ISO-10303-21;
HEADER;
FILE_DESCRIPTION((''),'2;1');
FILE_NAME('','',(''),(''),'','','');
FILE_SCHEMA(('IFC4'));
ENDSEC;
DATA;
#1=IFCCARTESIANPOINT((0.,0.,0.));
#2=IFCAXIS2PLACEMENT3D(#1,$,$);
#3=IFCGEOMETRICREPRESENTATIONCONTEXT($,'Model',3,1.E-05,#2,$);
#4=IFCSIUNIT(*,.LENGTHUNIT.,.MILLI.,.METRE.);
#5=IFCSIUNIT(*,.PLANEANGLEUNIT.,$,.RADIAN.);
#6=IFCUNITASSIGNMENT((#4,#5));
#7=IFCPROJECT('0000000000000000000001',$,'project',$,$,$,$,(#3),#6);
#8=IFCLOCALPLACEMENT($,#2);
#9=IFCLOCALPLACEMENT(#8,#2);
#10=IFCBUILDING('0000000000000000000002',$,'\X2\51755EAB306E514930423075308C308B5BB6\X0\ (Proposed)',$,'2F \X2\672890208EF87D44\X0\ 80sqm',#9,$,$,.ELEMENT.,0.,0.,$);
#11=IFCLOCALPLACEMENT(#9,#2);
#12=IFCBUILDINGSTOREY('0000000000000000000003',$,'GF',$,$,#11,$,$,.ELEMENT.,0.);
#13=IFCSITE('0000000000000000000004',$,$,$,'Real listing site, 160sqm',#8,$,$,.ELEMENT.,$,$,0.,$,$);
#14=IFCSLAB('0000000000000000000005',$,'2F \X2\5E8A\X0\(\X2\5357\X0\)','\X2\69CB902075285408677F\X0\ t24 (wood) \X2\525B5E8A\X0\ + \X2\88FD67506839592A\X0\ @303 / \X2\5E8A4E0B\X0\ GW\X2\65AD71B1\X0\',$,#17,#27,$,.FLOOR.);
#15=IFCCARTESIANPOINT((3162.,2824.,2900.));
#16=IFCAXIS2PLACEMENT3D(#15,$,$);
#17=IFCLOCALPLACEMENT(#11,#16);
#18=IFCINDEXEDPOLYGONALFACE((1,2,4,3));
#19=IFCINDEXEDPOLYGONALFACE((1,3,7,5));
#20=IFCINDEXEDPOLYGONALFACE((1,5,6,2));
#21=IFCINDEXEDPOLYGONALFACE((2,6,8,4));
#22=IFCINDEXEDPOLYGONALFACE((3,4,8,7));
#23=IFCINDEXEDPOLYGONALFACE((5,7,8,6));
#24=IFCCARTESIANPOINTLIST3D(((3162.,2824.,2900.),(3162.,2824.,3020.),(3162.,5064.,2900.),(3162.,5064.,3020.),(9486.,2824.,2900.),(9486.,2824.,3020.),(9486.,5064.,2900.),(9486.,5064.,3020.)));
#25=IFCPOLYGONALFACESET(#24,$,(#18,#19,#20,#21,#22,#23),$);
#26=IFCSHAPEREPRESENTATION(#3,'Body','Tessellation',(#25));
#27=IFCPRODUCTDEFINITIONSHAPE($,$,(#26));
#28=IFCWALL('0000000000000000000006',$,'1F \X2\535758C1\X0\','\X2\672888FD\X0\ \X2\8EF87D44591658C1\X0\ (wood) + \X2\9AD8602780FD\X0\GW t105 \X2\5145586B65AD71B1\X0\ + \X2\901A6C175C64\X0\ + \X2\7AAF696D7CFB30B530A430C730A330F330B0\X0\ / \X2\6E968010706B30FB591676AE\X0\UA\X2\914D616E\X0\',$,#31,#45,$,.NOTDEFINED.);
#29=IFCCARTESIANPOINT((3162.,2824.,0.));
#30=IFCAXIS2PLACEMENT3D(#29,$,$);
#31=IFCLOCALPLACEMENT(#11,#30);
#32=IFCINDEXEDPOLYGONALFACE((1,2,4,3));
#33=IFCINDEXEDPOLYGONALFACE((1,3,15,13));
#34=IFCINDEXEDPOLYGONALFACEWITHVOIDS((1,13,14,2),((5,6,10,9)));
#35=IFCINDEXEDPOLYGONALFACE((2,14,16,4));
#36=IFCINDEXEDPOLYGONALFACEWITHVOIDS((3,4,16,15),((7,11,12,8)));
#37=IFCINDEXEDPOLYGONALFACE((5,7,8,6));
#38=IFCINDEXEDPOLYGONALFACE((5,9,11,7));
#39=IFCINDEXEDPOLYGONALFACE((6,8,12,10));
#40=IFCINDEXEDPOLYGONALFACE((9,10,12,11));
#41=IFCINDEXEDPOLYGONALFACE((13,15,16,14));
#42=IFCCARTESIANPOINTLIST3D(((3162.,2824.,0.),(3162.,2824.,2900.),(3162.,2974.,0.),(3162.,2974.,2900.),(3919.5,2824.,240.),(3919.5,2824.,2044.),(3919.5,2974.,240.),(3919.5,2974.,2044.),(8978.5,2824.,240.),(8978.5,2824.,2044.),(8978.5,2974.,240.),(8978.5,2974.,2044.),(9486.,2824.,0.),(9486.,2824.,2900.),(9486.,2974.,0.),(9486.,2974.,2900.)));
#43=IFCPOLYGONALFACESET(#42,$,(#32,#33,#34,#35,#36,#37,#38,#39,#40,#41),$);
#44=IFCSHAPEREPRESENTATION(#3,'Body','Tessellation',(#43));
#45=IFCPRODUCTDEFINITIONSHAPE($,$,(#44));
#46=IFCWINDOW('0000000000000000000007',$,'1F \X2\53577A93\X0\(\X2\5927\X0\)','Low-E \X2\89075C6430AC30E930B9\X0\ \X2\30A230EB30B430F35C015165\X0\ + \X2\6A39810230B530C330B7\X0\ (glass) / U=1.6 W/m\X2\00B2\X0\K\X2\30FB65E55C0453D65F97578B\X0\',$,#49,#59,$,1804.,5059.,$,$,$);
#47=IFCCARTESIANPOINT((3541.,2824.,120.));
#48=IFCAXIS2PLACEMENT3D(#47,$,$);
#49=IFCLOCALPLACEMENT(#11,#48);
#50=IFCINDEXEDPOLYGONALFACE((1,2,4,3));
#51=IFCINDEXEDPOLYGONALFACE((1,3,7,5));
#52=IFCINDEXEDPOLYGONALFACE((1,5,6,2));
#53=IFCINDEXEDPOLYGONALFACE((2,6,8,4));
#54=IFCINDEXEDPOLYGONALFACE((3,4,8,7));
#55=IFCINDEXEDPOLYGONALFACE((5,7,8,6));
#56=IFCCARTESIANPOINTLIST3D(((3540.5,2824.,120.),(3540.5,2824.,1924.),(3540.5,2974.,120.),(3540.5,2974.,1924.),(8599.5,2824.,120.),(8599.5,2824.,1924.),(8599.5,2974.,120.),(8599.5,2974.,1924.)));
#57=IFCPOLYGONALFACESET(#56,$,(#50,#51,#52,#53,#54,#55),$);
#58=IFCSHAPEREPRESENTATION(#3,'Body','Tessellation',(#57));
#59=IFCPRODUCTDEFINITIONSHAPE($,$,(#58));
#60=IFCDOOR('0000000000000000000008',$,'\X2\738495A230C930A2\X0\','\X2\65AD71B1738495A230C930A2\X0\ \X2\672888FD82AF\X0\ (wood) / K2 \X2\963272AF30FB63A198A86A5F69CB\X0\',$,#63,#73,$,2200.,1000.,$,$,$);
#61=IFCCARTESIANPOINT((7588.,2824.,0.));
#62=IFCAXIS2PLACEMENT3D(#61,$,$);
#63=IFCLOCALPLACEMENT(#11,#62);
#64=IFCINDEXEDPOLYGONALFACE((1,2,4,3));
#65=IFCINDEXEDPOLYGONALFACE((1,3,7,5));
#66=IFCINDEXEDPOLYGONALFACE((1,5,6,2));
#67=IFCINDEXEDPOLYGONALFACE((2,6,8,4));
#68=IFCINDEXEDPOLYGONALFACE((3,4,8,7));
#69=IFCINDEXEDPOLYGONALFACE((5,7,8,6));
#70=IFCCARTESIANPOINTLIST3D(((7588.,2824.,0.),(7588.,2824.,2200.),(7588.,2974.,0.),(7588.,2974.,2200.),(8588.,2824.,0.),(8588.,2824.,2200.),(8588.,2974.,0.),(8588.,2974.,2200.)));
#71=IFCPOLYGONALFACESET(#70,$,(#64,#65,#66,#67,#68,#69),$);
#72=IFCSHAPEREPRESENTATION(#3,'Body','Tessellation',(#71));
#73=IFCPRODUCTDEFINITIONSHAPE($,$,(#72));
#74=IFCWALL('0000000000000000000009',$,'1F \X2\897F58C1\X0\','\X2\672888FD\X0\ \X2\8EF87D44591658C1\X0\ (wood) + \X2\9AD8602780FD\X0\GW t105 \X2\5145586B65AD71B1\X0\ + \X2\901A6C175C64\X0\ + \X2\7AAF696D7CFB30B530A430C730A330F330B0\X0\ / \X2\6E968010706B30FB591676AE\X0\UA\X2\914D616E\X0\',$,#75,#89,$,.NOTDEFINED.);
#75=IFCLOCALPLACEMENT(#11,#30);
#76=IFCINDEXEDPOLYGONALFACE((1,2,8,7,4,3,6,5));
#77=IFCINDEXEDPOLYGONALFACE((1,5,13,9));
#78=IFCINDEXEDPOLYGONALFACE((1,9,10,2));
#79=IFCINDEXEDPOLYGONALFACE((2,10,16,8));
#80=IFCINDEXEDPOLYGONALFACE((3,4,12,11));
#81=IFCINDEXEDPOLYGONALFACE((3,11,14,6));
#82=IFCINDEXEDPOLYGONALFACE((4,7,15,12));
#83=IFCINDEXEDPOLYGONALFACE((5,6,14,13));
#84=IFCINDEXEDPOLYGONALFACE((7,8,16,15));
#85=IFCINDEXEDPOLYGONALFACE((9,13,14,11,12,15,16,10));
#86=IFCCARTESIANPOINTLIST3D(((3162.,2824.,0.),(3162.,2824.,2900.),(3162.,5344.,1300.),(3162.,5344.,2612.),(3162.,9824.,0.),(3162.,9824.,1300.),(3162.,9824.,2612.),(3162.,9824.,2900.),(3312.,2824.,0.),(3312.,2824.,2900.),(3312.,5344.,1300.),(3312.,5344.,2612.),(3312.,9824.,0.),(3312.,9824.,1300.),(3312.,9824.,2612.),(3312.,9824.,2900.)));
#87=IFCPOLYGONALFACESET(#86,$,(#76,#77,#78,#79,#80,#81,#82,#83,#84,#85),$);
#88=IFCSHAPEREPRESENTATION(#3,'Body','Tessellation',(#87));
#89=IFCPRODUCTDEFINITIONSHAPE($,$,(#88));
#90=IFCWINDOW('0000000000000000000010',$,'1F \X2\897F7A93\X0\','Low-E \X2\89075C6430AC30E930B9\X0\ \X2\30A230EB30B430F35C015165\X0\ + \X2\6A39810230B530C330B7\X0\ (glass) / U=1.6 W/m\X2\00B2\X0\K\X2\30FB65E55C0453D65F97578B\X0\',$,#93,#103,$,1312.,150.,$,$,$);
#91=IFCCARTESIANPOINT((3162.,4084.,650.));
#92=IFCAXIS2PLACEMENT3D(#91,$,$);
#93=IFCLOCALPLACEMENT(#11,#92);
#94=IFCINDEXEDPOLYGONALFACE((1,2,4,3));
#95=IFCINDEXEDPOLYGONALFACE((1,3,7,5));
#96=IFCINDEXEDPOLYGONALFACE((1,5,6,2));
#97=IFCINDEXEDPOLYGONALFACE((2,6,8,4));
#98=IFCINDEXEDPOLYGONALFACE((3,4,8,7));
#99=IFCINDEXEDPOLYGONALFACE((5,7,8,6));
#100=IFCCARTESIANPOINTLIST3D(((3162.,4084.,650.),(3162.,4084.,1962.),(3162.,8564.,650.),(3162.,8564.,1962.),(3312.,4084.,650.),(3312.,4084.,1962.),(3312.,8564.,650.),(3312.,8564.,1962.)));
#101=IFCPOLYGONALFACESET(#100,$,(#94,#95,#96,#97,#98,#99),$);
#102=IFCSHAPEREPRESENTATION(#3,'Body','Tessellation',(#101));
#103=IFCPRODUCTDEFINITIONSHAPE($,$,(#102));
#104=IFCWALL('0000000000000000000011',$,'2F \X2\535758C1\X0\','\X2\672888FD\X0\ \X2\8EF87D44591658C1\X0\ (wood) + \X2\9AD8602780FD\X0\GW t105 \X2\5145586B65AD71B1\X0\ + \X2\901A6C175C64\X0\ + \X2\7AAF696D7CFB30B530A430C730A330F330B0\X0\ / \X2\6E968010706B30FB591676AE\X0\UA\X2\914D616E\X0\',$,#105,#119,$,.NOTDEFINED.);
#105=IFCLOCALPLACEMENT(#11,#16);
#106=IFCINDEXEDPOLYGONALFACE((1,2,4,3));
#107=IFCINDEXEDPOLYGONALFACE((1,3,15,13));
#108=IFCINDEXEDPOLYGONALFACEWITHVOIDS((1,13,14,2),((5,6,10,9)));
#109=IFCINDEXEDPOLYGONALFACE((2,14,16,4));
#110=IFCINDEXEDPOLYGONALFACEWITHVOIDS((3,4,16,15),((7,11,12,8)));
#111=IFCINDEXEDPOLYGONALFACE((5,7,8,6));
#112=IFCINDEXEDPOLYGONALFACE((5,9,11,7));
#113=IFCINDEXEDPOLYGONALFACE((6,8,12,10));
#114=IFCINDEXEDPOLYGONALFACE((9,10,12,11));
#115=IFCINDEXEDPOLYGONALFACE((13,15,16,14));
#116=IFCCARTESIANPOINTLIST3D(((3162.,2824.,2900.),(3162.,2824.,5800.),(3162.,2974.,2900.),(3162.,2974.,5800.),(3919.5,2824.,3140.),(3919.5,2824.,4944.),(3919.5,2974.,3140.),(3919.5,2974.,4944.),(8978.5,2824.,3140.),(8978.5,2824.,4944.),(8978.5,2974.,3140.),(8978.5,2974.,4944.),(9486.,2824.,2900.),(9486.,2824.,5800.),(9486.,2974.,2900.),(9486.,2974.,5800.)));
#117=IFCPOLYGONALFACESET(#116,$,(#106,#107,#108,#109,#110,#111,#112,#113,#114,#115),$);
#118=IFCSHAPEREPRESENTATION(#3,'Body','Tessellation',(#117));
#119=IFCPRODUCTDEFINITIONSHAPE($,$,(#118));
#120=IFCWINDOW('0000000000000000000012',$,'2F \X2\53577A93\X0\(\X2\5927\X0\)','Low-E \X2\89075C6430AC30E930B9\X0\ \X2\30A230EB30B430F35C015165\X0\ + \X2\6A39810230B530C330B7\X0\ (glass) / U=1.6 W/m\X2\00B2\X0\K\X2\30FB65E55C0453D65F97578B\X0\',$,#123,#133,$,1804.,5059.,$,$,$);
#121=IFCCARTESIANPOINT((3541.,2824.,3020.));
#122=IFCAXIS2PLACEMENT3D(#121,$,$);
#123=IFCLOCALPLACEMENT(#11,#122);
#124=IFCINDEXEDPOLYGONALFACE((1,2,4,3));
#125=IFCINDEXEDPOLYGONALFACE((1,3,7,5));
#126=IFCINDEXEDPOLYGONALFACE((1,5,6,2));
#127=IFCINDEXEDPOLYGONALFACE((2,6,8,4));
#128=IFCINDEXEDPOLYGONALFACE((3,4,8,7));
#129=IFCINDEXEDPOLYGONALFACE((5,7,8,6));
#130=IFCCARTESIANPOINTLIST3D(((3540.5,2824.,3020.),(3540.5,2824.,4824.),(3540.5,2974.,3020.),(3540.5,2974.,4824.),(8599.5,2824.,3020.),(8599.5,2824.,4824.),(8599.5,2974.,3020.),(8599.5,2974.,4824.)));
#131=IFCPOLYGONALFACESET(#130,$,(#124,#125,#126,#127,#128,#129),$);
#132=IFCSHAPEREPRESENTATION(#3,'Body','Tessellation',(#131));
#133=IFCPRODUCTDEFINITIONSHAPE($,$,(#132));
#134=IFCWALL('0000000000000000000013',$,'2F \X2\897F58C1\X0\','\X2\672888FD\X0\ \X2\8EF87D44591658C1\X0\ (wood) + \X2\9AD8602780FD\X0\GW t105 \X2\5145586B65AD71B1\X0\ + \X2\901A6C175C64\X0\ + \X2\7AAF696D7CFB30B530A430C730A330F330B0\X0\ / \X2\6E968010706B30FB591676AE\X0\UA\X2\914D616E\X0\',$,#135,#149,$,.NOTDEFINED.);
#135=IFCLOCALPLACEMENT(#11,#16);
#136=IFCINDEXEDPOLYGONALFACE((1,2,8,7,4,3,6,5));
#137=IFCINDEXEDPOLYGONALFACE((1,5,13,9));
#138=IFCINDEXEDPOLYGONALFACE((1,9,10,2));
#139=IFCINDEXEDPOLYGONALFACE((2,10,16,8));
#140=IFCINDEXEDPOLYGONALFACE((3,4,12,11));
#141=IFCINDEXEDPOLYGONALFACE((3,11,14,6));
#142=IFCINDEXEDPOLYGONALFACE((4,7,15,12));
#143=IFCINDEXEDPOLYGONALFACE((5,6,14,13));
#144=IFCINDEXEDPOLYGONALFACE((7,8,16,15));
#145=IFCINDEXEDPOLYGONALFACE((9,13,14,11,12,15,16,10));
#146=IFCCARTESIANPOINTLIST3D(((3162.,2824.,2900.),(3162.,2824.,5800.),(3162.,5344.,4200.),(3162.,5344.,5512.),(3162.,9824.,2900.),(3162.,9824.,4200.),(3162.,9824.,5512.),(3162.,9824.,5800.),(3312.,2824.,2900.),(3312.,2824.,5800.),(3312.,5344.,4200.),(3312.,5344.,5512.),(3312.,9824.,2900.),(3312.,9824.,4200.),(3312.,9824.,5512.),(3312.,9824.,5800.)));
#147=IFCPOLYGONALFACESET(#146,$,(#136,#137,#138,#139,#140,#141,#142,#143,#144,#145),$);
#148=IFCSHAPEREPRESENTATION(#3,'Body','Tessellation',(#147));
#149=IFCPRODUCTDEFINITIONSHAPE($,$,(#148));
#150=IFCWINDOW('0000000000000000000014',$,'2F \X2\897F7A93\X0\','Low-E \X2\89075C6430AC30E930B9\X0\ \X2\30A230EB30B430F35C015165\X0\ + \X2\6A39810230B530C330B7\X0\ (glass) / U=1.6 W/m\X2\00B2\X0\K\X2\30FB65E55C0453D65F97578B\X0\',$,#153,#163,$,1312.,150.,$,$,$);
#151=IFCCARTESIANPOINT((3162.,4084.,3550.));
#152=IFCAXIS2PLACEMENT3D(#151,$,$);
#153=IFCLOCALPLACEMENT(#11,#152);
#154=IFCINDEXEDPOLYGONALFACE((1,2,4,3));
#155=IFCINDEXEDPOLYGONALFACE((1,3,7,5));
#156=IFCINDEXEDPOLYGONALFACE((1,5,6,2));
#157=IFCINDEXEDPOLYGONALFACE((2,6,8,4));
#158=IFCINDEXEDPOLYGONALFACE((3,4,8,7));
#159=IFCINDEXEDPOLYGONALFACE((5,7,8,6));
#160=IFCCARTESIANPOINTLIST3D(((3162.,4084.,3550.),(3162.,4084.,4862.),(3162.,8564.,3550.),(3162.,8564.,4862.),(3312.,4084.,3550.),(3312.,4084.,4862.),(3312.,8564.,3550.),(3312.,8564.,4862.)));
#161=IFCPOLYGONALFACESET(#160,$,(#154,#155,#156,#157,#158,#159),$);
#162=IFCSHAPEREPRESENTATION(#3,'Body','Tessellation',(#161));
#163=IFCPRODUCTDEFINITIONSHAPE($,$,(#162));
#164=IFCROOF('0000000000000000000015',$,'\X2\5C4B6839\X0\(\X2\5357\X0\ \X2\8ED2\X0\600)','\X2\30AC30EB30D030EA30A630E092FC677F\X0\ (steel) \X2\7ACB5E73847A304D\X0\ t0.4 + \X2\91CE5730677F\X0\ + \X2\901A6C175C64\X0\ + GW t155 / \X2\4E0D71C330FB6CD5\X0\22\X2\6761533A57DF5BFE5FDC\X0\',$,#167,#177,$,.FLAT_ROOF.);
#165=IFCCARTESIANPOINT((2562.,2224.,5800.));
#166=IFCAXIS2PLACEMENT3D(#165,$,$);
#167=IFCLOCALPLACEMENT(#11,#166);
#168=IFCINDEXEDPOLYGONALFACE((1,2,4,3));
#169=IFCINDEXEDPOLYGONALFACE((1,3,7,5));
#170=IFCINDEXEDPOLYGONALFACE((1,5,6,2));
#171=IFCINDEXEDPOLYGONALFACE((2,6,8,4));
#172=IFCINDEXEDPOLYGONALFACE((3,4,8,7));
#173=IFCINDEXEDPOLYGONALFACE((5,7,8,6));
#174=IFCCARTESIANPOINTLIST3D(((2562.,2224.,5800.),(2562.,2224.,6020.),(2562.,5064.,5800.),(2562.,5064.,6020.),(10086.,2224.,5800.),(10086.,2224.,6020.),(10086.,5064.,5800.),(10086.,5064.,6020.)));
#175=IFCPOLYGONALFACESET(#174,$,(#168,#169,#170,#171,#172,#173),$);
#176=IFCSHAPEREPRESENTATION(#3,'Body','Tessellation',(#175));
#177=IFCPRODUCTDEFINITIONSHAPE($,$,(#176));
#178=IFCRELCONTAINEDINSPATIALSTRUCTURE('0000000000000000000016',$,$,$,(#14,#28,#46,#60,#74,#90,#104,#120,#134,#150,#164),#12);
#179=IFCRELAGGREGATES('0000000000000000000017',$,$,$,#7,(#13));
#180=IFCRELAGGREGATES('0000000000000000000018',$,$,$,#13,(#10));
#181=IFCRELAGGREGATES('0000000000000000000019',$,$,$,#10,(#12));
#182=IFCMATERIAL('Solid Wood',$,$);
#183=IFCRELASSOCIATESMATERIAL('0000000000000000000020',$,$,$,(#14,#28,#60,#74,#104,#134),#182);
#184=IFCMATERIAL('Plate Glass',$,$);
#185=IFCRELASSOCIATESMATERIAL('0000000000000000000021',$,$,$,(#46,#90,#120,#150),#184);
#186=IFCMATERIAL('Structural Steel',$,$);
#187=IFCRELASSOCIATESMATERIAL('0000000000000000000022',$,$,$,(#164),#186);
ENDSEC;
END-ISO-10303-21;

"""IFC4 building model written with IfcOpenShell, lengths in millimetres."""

from ifc_helpers import new_model, si_unit, frame, frame_2d, origin, place, context, project, spatial, rectangle, extrude, material, element, fill, save


model = new_model("IFC4")

# Units and contexts
model_context = context("Model", 3, precision=1e-05, world=origin())
ifc_project = project(units=[si_unit("LENGTHUNIT", "METRE", prefix="MILLI"), si_unit("PLANEANGLEUNIT", "RADIAN")], contexts=[model_context])

# Site, building, storey
site_placement = place(None, origin())
site = spatial("IfcSite", under=ifc_project, at=site_placement, ObjectType="Real listing site, 160sqm", CompositionType="ELEMENT", RefElevation=0.0)
building_placement = place(site_placement, origin())
building = spatial("IfcBuilding", under=site, at=building_placement, Name="兵庫の光あふれる家 (Proposed)", ObjectType="2F 木造軸組 80sqm", CompositionType="ELEMENT", ElevationOfRefHeight=0.0, ElevationOfTerrain=0.0)
storey_placement = place(building_placement, origin())
storey = spatial("IfcBuildingStorey", under=building, at=storey_placement, Name="GF", CompositionType="ELEMENT", Elevation=0.0)

# Slab
ifc_material_1 = material(Name="Solid Wood")
slab_1_placement = place(storey_placement, frame((3162.0, 2824.0, 2900.0)))
element("IfcSlab", 1, at=slab_1_placement, inside=storey, material=ifc_material_1, Name="2F 床(南)", Description="構造用合板 t24 (wood) 剛床 + 製材根太 @303 / 床下 GW断熱", PredefinedType="FLOOR", context=model_context, shape_type="SweptSolid", body=[
    extrude(rectangle(XDim=6324.0, YDim=2240.0, at=frame_2d((3162.0, 1120.0))), frame((3162.0, 2824.0, 2900.0)), (0.0, 0.0, 1.0), 120.0),
])

# Wall, openings, window, door
wall_1_placement = place(storey_placement, frame((3162.0, 2824.0, 0.0)))
wall_1 = element("IfcWall", 2, at=wall_1_placement, inside=storey, material=ifc_material_1, Name="1F 南壁", Description="木製 軸組外壁 (wood) + 高性能GW t105 充填断熱 + 通気層 + 窯業系サイディング / 準耐火・外皮UA配慮", PredefinedType="NOTDEFINED", context=model_context, shape_type="SweptSolid", body=[
    extrude(rectangle(XDim=6324.0, YDim=150.0, at=frame_2d((3162.0, 75.0))), frame((3162.0, 2824.0, 0.0)), (0.0, 0.0, 1.0), 2900.0),
])
opening_1_placement = place(storey_placement, frame((3541.0, 2824.0, 120.0)))
opening_1 = element("IfcOpeningElement", 3, at=opening_1_placement, cuts=wall_1, PredefinedType="NOTDEFINED", context=model_context, shape_type="SweptSolid", body=[
    extrude(rectangle(XDim=5059.0, YDim=150.0, at=frame_2d((2529.0, 75.0))), frame((3541.0, 2824.0, 120.0)), (0.0, 0.0, 1.0), 1804.0),
])
opening_2_placement = place(storey_placement, frame((7588.0, 2824.0, 0.0)))
opening_2 = element("IfcOpeningElement", 4, at=opening_2_placement, cuts=wall_1, PredefinedType="NOTDEFINED", context=model_context, shape_type="SweptSolid", body=[
    extrude(rectangle(XDim=1000.0, YDim=150.0, at=frame_2d((500.0, 75.0))), frame((7588.0, 2824.0, 0.0)), (0.0, 0.0, 1.0), 2200.0),
])
ifc_material_2 = material(Name="Plate Glass")
window_1_placement = place(storey_placement, frame((3541.0, 2824.0, 120.0)))
window_1 = element("IfcWindow", 5, at=window_1_placement, inside=storey, material=ifc_material_2, Name="1F 南窓(大)", Description="Low-E 複層ガラス アルゴン封入 + 樹脂サッシ (glass) / U=1.6 W/m²K・日射取得型", OverallHeight=1804.0, OverallWidth=5059.0, context=model_context, shape_type="SweptSolid", body=[
    extrude(rectangle(XDim=5059.0, YDim=150.0, at=frame_2d((2529.0, 75.0))), frame((3541.0, 2824.0, 120.0)), (0.0, 0.0, 1.0), 1804.0),
])
fill(opening_1, window_1)
door_placement = place(storey_placement, frame((7588.0, 2824.0, 0.0)))
door = element("IfcDoor", 6, at=door_placement, inside=storey, material=ifc_material_1, Name="玄関ドア", Description="断熱玄関ドア 木製芯 (wood) / K2 防犯・採風機構", OverallHeight=2200.0, OverallWidth=1000.0, context=model_context, shape_type="SweptSolid", body=[
    extrude(rectangle(XDim=1000.0, YDim=150.0, at=frame_2d((500.0, 75.0))), frame((7588.0, 2824.0, 0.0)), (0.0, 0.0, 1.0), 2200.0),
])
fill(opening_2, door)

# Walls, openings, windows
wall_2_placement = place(storey_placement, frame((3162.0, 2824.0, 0.0)))
wall_2 = element("IfcWall", 7, at=wall_2_placement, inside=storey, material=ifc_material_1, Name="1F 西壁", Description="木製 軸組外壁 (wood) + 高性能GW t105 充填断熱 + 通気層 + 窯業系サイディング / 準耐火・外皮UA配慮", PredefinedType="NOTDEFINED", context=model_context, shape_type="SweptSolid", body=[
    extrude(rectangle(XDim=150.0, YDim=7000.0, at=frame_2d((75.0, 3500.0))), frame((3162.0, 2824.0, 0.0)), (0.0, 0.0, 1.0), 2900.0),
])
opening_3_placement = place(storey_placement, frame((3162.0, 4084.0, 650.0)))
opening_3 = element("IfcOpeningElement", 8, at=opening_3_placement, cuts=wall_2, PredefinedType="NOTDEFINED", context=model_context, shape_type="SweptSolid", body=[
    extrude(rectangle(XDim=150.0, YDim=4480.0, at=frame_2d((75.0, 2240.0))), frame((3162.0, 4084.0, 650.0)), (0.0, 0.0, 1.0), 1312.0),
])
window_2_placement = place(storey_placement, frame((3162.0, 4084.0, 650.0)))
window_2 = element("IfcWindow", 9, at=window_2_placement, inside=storey, material=ifc_material_2, Name="1F 西窓", Description="Low-E 複層ガラス アルゴン封入 + 樹脂サッシ (glass) / U=1.6 W/m²K・日射取得型", OverallHeight=1312.0, OverallWidth=150.0, context=model_context, shape_type="SweptSolid", body=[
    extrude(rectangle(XDim=150.0, YDim=4480.0, at=frame_2d((75.0, 2240.0))), frame((3162.0, 4084.0, 650.0)), (0.0, 0.0, 1.0), 1312.0),
])
fill(opening_3, window_2)
wall_3_placement = place(storey_placement, frame((3162.0, 2824.0, 2900.0)))
wall_3 = element("IfcWall", 10, at=wall_3_placement, inside=storey, material=ifc_material_1, Name="2F 南壁", Description="木製 軸組外壁 (wood) + 高性能GW t105 充填断熱 + 通気層 + 窯業系サイディング / 準耐火・外皮UA配慮", PredefinedType="NOTDEFINED", context=model_context, shape_type="SweptSolid", body=[
    extrude(rectangle(XDim=6324.0, YDim=150.0, at=frame_2d((3162.0, 75.0))), frame((3162.0, 2824.0, 2900.0)), (0.0, 0.0, 1.0), 2900.0),
])
opening_4_placement = place(storey_placement, frame((3541.0, 2824.0, 3020.0)))
opening_4 = element("IfcOpeningElement", 11, at=opening_4_placement, cuts=wall_3, PredefinedType="NOTDEFINED", context=model_context, shape_type="SweptSolid", body=[
    extrude(rectangle(XDim=5059.0, YDim=150.0, at=frame_2d((2529.0, 75.0))), frame((3541.0, 2824.0, 3020.0)), (0.0, 0.0, 1.0), 1804.0),
])
window_3_placement = place(storey_placement, frame((3541.0, 2824.0, 3020.0)))
window_3 = element("IfcWindow", 12, at=window_3_placement, inside=storey, material=ifc_material_2, Name="2F 南窓(大)", Description="Low-E 複層ガラス アルゴン封入 + 樹脂サッシ (glass) / U=1.6 W/m²K・日射取得型", OverallHeight=1804.0, OverallWidth=5059.0, context=model_context, shape_type="SweptSolid", body=[
    extrude(rectangle(XDim=5059.0, YDim=150.0, at=frame_2d((2529.0, 75.0))), frame((3541.0, 2824.0, 3020.0)), (0.0, 0.0, 1.0), 1804.0),
])
fill(opening_4, window_3)
wall_4_placement = place(storey_placement, frame((3162.0, 2824.0, 2900.0)))
wall_4 = element("IfcWall", 13, at=wall_4_placement, inside=storey, material=ifc_material_1, Name="2F 西壁", Description="木製 軸組外壁 (wood) + 高性能GW t105 充填断熱 + 通気層 + 窯業系サイディング / 準耐火・外皮UA配慮", PredefinedType="NOTDEFINED", context=model_context, shape_type="SweptSolid", body=[
    extrude(rectangle(XDim=150.0, YDim=7000.0, at=frame_2d((75.0, 3500.0))), frame((3162.0, 2824.0, 2900.0)), (0.0, 0.0, 1.0), 2900.0),
])
opening_5_placement = place(storey_placement, frame((3162.0, 4084.0, 3550.0)))
opening_5 = element("IfcOpeningElement", 14, at=opening_5_placement, cuts=wall_4, PredefinedType="NOTDEFINED", context=model_context, shape_type="SweptSolid", body=[
    extrude(rectangle(XDim=150.0, YDim=4480.0, at=frame_2d((75.0, 2240.0))), frame((3162.0, 4084.0, 3550.0)), (0.0, 0.0, 1.0), 1312.0),
])
window_4_placement = place(storey_placement, frame((3162.0, 4084.0, 3550.0)))
window_4 = element("IfcWindow", 15, at=window_4_placement, inside=storey, material=ifc_material_2, Name="2F 西窓", Description="Low-E 複層ガラス アルゴン封入 + 樹脂サッシ (glass) / U=1.6 W/m²K・日射取得型", OverallHeight=1312.0, OverallWidth=150.0, context=model_context, shape_type="SweptSolid", body=[
    extrude(rectangle(XDim=150.0, YDim=4480.0, at=frame_2d((75.0, 2240.0))), frame((3162.0, 4084.0, 3550.0)), (0.0, 0.0, 1.0), 1312.0),
])
fill(opening_5, window_4)

# Roof
ifc_material_3 = material(Name="Structural Steel")
roof_1_placement = place(storey_placement, frame((2562.0, 2224.0, 5800.0)))
element("IfcRoof", 16, at=roof_1_placement, inside=storey, material=ifc_material_3, Name="屋根(南 軒600)", Description="ガルバリウム鋼板 (steel) 立平葺き t0.4 + 野地板 + 通気層 + GW t155 / 不燃・法22条区域対応", PredefinedType="FLAT_ROOF", context=model_context, shape_type="SweptSolid", body=[
    extrude(rectangle(XDim=7524.0, YDim=2840.0, at=frame_2d((3762.0, 1420.0))), frame((2562.0, 2224.0, 5800.0)), (0.0, 0.0, 1.0), 220.0),
])

save(model, "model.ifc")
